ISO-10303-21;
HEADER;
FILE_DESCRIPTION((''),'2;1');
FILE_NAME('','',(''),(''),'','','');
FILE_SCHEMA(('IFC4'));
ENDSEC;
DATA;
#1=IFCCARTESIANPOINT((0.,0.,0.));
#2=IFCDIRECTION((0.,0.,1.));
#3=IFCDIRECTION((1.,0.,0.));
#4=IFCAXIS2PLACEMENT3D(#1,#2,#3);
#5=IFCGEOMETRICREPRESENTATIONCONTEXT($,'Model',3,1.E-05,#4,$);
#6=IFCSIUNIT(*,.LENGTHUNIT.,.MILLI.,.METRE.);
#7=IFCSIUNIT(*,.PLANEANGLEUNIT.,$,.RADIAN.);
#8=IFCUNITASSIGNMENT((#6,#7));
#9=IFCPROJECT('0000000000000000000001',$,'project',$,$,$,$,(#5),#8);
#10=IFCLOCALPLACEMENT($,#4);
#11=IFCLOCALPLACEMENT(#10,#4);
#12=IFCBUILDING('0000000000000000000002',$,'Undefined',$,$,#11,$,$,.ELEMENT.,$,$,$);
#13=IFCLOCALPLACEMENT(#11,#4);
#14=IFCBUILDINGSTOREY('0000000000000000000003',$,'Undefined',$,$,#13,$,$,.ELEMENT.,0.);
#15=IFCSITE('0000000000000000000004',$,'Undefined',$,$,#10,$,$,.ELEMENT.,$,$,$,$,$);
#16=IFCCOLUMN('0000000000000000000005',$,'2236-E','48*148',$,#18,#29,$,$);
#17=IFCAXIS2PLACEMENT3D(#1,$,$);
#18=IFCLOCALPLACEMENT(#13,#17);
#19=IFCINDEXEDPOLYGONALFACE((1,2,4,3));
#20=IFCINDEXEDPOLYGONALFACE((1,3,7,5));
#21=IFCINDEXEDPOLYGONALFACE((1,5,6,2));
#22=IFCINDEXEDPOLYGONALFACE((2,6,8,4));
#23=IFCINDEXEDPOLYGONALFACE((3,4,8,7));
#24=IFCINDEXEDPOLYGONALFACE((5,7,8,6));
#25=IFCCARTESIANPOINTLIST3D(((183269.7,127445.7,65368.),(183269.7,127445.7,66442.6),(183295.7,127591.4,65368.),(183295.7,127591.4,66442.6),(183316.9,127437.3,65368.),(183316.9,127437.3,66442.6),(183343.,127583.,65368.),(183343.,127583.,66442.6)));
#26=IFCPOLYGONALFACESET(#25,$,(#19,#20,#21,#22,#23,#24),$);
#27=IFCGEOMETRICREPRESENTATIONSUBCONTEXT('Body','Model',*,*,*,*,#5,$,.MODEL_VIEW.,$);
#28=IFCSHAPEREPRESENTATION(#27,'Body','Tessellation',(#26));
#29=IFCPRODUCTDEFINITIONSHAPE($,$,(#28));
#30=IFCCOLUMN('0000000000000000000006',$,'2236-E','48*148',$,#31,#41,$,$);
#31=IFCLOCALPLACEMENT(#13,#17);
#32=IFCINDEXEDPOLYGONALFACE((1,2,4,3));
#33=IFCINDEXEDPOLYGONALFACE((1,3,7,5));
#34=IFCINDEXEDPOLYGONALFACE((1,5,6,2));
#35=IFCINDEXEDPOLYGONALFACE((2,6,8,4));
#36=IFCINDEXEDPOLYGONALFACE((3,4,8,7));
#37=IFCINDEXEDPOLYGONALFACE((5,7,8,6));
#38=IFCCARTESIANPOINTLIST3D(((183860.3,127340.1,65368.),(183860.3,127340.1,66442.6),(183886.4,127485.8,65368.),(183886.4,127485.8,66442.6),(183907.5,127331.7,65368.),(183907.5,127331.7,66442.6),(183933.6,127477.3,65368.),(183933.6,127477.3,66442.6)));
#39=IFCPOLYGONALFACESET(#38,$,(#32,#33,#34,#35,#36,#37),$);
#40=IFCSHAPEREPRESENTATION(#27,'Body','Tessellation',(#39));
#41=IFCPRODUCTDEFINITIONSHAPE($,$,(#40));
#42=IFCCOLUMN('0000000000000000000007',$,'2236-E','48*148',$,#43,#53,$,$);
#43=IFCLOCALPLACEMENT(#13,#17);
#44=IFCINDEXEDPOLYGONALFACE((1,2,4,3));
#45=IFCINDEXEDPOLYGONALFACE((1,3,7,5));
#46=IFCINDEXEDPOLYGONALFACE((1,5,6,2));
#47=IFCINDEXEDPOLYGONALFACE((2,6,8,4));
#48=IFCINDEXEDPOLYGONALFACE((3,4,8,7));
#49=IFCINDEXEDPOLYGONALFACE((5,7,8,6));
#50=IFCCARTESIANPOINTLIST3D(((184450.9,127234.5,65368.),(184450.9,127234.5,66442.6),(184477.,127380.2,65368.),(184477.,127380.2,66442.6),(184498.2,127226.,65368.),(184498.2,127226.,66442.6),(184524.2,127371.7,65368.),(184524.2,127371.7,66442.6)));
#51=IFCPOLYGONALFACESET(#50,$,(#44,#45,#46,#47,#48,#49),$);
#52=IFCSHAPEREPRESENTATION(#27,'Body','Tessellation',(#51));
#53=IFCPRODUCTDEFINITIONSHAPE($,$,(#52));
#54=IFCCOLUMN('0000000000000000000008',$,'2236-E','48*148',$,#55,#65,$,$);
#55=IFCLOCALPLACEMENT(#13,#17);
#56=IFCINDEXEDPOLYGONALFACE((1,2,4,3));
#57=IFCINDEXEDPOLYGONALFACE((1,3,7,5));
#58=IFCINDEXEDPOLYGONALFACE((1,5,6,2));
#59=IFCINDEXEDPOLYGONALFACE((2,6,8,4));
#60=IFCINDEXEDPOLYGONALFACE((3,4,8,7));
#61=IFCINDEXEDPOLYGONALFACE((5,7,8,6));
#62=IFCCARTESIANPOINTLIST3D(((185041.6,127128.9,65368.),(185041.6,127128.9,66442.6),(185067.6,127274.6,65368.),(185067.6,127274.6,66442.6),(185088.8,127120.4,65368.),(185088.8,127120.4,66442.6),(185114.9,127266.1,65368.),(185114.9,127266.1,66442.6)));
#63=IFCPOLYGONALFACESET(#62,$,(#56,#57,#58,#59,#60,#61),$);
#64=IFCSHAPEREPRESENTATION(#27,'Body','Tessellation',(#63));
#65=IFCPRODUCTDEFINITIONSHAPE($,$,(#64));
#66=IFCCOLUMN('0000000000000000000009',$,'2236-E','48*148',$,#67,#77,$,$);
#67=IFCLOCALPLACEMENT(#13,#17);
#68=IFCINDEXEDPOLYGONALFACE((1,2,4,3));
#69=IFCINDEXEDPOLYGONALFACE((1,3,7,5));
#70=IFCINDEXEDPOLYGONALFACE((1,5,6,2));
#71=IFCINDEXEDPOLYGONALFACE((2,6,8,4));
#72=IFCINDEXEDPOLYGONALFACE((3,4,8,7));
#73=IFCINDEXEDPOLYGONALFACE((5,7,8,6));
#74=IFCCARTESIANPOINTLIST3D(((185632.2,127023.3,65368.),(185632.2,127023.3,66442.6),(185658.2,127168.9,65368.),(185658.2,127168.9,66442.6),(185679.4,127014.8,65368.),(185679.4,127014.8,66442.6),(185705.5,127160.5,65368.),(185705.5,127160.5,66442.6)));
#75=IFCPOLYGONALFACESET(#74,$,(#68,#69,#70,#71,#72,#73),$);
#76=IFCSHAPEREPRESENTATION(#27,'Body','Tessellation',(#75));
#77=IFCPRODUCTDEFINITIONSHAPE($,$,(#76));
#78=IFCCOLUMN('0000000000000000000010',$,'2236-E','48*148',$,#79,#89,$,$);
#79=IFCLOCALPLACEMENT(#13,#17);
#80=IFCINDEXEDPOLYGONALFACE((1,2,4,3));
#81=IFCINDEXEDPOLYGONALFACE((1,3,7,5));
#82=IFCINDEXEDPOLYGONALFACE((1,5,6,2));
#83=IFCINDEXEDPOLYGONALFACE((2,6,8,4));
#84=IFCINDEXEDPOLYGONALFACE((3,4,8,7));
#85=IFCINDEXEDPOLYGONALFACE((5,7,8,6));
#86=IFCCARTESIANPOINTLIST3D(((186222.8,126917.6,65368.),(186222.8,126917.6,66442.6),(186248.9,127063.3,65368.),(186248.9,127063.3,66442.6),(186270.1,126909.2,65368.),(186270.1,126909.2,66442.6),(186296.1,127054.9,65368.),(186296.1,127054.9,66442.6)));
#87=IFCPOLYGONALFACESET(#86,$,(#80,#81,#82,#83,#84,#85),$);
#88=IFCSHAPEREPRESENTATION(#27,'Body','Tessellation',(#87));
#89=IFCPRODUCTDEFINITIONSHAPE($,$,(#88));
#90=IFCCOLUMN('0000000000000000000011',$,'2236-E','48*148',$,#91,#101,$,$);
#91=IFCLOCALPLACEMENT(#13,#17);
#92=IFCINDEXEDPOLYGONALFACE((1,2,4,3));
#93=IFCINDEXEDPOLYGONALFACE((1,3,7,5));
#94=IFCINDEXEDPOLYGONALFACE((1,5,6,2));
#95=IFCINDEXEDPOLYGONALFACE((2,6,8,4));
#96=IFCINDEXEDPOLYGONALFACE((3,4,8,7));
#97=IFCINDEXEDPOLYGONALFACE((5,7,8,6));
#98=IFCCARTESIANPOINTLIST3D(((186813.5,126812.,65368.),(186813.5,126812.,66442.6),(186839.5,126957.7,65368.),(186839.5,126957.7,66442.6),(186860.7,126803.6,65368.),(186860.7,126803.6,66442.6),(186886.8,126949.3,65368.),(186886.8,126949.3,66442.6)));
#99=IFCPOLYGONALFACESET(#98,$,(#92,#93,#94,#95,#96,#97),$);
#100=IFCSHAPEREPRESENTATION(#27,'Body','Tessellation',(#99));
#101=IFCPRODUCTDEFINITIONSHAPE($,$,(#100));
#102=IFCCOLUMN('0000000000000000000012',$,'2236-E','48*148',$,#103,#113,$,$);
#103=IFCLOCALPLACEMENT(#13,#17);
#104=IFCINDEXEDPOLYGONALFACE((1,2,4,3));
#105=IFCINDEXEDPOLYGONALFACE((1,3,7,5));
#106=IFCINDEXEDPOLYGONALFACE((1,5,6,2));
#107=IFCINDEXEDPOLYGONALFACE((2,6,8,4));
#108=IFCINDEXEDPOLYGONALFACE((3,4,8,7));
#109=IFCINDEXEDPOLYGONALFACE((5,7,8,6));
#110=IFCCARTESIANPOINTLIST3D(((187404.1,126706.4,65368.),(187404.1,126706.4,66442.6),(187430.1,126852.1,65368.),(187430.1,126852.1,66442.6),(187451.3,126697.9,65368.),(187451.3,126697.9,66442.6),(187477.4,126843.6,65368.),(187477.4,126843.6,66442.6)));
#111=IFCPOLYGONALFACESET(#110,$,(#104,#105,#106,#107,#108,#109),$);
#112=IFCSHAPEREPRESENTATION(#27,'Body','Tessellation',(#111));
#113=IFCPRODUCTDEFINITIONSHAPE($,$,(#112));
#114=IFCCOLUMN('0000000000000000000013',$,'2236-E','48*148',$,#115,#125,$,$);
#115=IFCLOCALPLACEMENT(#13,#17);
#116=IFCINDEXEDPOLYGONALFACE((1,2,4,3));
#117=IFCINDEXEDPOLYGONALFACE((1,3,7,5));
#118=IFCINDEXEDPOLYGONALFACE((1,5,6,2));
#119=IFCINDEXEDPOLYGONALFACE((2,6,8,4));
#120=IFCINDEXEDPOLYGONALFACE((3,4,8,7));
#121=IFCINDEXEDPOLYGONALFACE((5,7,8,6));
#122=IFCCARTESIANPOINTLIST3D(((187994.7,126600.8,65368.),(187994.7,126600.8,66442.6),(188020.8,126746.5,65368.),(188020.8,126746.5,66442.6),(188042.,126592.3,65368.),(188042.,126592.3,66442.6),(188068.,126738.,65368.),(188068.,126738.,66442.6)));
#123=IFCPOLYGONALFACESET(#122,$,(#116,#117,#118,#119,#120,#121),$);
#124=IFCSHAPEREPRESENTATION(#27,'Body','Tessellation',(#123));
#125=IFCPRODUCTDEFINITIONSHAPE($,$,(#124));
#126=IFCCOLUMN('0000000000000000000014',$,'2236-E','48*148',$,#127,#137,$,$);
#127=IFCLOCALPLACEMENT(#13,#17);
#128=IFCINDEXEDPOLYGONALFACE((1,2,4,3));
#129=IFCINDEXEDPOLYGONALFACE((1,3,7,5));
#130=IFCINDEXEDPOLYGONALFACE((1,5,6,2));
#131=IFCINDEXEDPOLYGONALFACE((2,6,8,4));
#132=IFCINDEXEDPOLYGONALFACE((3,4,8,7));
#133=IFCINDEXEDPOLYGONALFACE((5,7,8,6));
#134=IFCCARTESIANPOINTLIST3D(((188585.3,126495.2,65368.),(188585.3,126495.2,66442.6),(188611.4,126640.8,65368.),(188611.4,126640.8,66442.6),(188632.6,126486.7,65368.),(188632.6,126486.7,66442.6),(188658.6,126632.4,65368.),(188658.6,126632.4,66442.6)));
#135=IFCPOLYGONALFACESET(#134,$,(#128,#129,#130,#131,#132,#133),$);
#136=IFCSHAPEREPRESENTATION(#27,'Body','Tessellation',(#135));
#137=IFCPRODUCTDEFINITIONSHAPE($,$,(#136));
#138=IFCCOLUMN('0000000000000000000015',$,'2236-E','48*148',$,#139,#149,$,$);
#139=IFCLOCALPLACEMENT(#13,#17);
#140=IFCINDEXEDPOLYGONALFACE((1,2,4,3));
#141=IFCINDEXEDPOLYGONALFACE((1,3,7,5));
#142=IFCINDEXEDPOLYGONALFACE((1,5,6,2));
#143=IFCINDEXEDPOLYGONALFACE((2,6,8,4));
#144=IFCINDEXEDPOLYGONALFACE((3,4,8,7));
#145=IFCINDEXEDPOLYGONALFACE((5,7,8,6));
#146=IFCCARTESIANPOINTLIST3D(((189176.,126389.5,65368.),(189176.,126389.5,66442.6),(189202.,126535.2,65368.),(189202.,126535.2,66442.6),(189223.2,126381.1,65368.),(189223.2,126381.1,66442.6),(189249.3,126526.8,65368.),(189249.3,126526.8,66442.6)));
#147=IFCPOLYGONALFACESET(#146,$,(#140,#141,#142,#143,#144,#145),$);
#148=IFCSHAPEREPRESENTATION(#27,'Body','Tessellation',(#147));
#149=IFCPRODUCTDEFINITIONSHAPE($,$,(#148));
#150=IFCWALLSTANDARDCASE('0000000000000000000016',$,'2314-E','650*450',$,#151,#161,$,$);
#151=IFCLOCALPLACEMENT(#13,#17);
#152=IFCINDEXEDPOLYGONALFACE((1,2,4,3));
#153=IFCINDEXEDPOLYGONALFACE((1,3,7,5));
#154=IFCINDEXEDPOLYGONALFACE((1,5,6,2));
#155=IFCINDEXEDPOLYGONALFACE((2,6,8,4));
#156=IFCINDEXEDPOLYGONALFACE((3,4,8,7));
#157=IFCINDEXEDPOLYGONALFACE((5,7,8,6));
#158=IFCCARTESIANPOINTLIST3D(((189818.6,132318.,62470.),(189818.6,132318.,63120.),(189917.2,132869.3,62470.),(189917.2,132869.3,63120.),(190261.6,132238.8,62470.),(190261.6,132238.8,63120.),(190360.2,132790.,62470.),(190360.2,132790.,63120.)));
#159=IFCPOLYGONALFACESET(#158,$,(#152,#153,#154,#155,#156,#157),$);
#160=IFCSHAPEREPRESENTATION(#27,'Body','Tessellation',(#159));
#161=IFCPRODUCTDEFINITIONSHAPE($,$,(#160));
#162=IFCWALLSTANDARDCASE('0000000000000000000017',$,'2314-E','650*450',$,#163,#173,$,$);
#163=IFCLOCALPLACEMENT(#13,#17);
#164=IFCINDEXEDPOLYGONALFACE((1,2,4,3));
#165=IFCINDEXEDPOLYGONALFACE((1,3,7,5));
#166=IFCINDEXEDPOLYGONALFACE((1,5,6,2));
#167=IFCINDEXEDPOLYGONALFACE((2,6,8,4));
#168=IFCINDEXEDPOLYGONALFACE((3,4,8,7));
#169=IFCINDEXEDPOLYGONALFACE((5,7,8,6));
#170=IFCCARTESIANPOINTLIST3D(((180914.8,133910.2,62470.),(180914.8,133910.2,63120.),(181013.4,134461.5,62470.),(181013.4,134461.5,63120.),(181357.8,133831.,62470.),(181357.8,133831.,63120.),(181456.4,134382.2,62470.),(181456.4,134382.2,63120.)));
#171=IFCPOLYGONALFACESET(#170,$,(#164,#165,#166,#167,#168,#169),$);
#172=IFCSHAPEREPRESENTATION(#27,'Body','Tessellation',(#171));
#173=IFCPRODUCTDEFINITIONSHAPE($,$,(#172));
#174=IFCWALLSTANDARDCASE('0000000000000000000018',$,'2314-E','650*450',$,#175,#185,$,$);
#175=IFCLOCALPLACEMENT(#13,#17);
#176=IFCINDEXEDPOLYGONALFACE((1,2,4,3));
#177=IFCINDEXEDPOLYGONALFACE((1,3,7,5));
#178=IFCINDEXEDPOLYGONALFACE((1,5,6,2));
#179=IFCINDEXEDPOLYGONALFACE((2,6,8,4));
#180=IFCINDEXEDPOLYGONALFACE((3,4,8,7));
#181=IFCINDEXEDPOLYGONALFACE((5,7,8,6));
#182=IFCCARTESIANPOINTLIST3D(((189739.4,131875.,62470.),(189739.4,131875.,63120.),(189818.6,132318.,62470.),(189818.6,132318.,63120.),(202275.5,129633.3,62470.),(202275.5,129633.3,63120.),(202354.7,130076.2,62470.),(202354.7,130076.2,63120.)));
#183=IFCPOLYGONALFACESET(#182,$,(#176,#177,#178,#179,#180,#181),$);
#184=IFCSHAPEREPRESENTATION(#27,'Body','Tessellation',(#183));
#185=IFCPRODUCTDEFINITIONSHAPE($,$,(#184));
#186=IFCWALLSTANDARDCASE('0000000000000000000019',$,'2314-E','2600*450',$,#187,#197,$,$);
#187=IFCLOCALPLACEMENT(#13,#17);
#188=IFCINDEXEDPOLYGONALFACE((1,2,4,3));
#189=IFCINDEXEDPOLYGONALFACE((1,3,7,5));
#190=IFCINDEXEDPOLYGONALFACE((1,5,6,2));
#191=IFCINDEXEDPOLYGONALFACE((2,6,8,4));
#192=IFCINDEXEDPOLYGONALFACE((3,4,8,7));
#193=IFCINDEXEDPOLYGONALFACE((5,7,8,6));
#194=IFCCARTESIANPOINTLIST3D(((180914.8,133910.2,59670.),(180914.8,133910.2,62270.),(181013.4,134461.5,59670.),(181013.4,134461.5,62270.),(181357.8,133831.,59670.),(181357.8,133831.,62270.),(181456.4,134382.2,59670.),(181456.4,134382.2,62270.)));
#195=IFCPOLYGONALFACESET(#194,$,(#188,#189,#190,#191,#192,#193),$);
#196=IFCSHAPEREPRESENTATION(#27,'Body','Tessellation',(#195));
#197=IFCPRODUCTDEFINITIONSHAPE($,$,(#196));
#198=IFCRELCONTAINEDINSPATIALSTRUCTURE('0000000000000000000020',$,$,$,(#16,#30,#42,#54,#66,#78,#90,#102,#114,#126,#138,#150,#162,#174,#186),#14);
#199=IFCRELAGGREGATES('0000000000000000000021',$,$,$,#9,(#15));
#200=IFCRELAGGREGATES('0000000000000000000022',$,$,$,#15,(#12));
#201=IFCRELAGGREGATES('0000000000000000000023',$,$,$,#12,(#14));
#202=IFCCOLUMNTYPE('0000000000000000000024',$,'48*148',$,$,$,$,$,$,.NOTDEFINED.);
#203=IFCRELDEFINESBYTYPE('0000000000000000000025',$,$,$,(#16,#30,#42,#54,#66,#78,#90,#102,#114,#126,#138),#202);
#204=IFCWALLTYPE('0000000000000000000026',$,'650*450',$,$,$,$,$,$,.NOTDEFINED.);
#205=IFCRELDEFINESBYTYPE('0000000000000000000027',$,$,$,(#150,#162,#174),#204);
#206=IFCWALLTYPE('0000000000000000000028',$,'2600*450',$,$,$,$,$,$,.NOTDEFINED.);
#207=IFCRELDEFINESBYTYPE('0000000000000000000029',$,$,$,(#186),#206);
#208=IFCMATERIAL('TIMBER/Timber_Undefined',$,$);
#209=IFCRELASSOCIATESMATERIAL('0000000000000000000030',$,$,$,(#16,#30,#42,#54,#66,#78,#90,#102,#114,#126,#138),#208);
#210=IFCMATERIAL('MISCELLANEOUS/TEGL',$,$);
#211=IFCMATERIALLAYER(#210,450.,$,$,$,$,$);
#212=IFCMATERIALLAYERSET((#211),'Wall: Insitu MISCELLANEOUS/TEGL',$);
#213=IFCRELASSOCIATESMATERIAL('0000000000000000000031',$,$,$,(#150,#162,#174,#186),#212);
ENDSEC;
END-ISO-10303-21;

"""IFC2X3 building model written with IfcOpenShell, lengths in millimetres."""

from ifc_helpers import new_model, si_unit, frame, frame_2d, origin_with_axes, origin_2d_with_axis, place, context, subcontext, project, spatial, rectangle, extrude, material, layer, layer_set, layer_usage, type_object, element, save


model = new_model("IFC2X3")

# Units and contexts
model_context = context("Model", 3, precision=1e-05, world=origin_with_axes())
body_context = subcontext(model_context, "Body", "Model", "MODEL_VIEW")
ifc_project = project(units=[si_unit("LENGTHUNIT", "METRE", prefix="MILLI"), si_unit("PLANEANGLEUNIT", "RADIAN")], contexts=[model_context])

# Site, building, storey
site_placement = place(None, origin_with_axes())
site = spatial("IfcSite", under=ifc_project, at=site_placement, Name="Undefined", CompositionType="ELEMENT")
building_placement = place(site_placement, origin_with_axes())
building = spatial("IfcBuilding", under=site, at=building_placement, Name="Undefined", CompositionType="ELEMENT")
storey_placement = place(building_placement, origin_with_axes())
storey = spatial("IfcBuildingStorey", under=building, at=storey_placement, Name="Undefined", CompositionType="ELEMENT", Elevation=0.0)

# Columns
ifc_material_1 = material(Name="TIMBER/Timber_Undefined")
column_type = type_object("IfcColumnType", Name="48*148", PredefinedType="NOTDEFINED")
for number, where, z_axis, x_axis, name in (
    (1, (183306.3, 127514.3, 66442.6), (0.0, 0.0, -1.0), (0.984385, -0.176032, 0.0), "2236-E"),
    (2, (183897.0, 127408.7, 66442.6), (0.0, 0.0, -1.0), (0.984385, -0.176032, 0.0), "2236-E"),
    (3, (184487.6, 127303.1, 66442.6), (0.0, 0.0, -1.0), (0.984385, -0.176032, 0.0), "2236-E"),
    (4, (185078.2, 127197.5, 66442.6), (0.0, 0.0, -1.0), (0.984385, -0.176032, 0.0), "2236-E"),
    (5, (185668.8, 127091.9, 66442.6), (0.0, 0.0, -1.0), (0.984385, -0.176032, 0.0), "2236-E"),
    (6, (186259.5, 126986.3, 66442.6), (0.0, 0.0, -1.0), (0.984385, -0.176032, 0.0), "2236-E"),
    (7, (186850.1, 126880.6, 66442.6), (0.0, 0.0, -1.0), (0.984385, -0.176032, 0.0), "2236-E"),
    (8, (187440.7, 126775.0, 66442.6), (0.0, 0.0, -1.0), (0.984385, -0.176032, 0.0), "2236-E"),
    (9, (188031.4, 126669.4, 66442.6), (0.0, 0.0, -1.0), (0.984385, -0.176032, 0.0), "2236-E"),
    (10, (188622.0, 126563.8, 66442.6), (0.0, 0.0, -1.0), (0.984385, -0.176032, 0.0), "2236-E"),
    (11, (189212.6, 126458.2, 66442.6), (0.0, 0.0, -1.0), (0.984385, -0.176032, 0.0), "2236-E"),
):
    element("IfcColumn", number, at=place(storey_placement, frame(where, z_axis=z_axis, x_axis=x_axis)), inside=storey, type_object=column_type, material=ifc_material_1, Name=name, Description="48*148", context=body_context, shape_type="SweptSolid", body=[
        extrude(rectangle(XDim=148.0, YDim=48.0, at=origin_2d_with_axis()), frame((0.0, 0.0, 1074.6), z_axis=(0.0, 0.0, -1.0), x_axis=(0.0, 1.0, 0.0)), (0.0, 0.0, 1.0), 1074.6),
    ])

# Walls
ifc_material_2 = material(Name="MISCELLANEOUS/TEGL")
ifc_layer_1 = layer(ifc_material_2, 450.0)
ifc_layer_set_1 = layer_set([ifc_layer_1], Name="Wall: Insitu MISCELLANEOUS/TEGL")
ifc_layer_usage_1 = layer_usage(ifc_layer_set_1, "AXIS2", "POSITIVE", -225.0)
wall_type_1 = type_object("IfcWallType", Name="650*450", PredefinedType="NOTDEFINED")
wall_1_placement = place(storey_placement, frame((190138.7, 132829.6, 62470.0), z_axis=(0.0, 0.0, 1.0), x_axis=(-0.176025, -0.984386, 0.0)))
element("IfcWallStandardCase", 12, at=wall_1_placement, inside=storey, type_object=wall_type_1, material=ifc_layer_usage_1, Name="2314-E", Description="650*450", context=body_context, shape_type="SweptSolid", body=[
    extrude(rectangle(XDim=560.0, YDim=450.0, at=frame_2d((0.0, 280.0), x_axis=(0.0, -1.0))), frame((0.0, 0.0, 0.0), z_axis=(0.0, 0.0, 1.0), x_axis=(0.0, -1.0, 0.0)), (0.0, 0.0, 1.0), 650.0),
])
ifc_layer_usage_2 = layer_usage(ifc_layer_set_1, "AXIS2", "POSITIVE", -225.0)
wall_2_placement = place(storey_placement, frame((181136.3, 133870.6, 62470.0), z_axis=(0.0, 0.0, 1.0), x_axis=(0.176029, 0.984385, 0.0)))
element("IfcWallStandardCase", 13, at=wall_2_placement, inside=storey, type_object=wall_type_1, material=ifc_layer_usage_2, Name="2314-E", Description="650*450", context=body_context, shape_type="SweptSolid", body=[
    extrude(rectangle(XDim=560.0, YDim=450.0, at=frame_2d((0.0, 280.0), x_axis=(0.0, -1.0))), frame((0.0, 0.0, 0.0), z_axis=(0.0, 0.0, 1.0), x_axis=(0.0, -1.0, 0.0)), (0.0, 0.0, 1.0), 650.0),
])
ifc_layer_usage_3 = layer_usage(ifc_layer_set_1, "AXIS2", "POSITIVE", -225.0)
wall_3_placement = place(storey_placement, frame((189779.0, 132096.5, 62470.0), z_axis=(0.0, 0.0, 1.0), x_axis=(0.984385, -0.176032, 0.0)))
element("IfcWallStandardCase", 14, at=wall_3_placement, inside=storey, type_object=wall_type_1, material=ifc_layer_usage_3, Name="2314-E", Description="650*450", context=body_context, shape_type="SweptSolid", body=[
    extrude(rectangle(XDim=12735.0, YDim=450.0, at=frame_2d((0.0, 6367.5), x_axis=(0.0, -1.0))), frame((0.0, 0.0, 0.0), z_axis=(0.0, 0.0, 1.0), x_axis=(0.0, -1.0, 0.0)), (0.0, 0.0, 1.0), 650.0),
])
ifc_layer_usage_4 = layer_usage(ifc_layer_set_1, "AXIS2", "POSITIVE", -225.0)
wall_type_2 = type_object("IfcWallType", Name="2600*450", PredefinedType="NOTDEFINED")
wall_4_placement = place(storey_placement, frame((181136.3, 133870.6, 59670.0), z_axis=(0.0, 0.0, 1.0), x_axis=(0.176029, 0.984385, 0.0)))
element("IfcWallStandardCase", 15, at=wall_4_placement, inside=storey, type_object=wall_type_2, material=ifc_layer_usage_4, Name="2314-E", Description="2600*450", context=body_context, shape_type="SweptSolid", body=[
    extrude(rectangle(XDim=560.0, YDim=450.0, at=frame_2d((0.0, 280.0), x_axis=(0.0, -1.0))), frame((0.0, 0.0, 0.0), z_axis=(0.0, 0.0, 1.0), x_axis=(0.0, -1.0, 0.0)), (0.0, 0.0, 1.0), 2600.0),
])

save(model, "model.ifc")
